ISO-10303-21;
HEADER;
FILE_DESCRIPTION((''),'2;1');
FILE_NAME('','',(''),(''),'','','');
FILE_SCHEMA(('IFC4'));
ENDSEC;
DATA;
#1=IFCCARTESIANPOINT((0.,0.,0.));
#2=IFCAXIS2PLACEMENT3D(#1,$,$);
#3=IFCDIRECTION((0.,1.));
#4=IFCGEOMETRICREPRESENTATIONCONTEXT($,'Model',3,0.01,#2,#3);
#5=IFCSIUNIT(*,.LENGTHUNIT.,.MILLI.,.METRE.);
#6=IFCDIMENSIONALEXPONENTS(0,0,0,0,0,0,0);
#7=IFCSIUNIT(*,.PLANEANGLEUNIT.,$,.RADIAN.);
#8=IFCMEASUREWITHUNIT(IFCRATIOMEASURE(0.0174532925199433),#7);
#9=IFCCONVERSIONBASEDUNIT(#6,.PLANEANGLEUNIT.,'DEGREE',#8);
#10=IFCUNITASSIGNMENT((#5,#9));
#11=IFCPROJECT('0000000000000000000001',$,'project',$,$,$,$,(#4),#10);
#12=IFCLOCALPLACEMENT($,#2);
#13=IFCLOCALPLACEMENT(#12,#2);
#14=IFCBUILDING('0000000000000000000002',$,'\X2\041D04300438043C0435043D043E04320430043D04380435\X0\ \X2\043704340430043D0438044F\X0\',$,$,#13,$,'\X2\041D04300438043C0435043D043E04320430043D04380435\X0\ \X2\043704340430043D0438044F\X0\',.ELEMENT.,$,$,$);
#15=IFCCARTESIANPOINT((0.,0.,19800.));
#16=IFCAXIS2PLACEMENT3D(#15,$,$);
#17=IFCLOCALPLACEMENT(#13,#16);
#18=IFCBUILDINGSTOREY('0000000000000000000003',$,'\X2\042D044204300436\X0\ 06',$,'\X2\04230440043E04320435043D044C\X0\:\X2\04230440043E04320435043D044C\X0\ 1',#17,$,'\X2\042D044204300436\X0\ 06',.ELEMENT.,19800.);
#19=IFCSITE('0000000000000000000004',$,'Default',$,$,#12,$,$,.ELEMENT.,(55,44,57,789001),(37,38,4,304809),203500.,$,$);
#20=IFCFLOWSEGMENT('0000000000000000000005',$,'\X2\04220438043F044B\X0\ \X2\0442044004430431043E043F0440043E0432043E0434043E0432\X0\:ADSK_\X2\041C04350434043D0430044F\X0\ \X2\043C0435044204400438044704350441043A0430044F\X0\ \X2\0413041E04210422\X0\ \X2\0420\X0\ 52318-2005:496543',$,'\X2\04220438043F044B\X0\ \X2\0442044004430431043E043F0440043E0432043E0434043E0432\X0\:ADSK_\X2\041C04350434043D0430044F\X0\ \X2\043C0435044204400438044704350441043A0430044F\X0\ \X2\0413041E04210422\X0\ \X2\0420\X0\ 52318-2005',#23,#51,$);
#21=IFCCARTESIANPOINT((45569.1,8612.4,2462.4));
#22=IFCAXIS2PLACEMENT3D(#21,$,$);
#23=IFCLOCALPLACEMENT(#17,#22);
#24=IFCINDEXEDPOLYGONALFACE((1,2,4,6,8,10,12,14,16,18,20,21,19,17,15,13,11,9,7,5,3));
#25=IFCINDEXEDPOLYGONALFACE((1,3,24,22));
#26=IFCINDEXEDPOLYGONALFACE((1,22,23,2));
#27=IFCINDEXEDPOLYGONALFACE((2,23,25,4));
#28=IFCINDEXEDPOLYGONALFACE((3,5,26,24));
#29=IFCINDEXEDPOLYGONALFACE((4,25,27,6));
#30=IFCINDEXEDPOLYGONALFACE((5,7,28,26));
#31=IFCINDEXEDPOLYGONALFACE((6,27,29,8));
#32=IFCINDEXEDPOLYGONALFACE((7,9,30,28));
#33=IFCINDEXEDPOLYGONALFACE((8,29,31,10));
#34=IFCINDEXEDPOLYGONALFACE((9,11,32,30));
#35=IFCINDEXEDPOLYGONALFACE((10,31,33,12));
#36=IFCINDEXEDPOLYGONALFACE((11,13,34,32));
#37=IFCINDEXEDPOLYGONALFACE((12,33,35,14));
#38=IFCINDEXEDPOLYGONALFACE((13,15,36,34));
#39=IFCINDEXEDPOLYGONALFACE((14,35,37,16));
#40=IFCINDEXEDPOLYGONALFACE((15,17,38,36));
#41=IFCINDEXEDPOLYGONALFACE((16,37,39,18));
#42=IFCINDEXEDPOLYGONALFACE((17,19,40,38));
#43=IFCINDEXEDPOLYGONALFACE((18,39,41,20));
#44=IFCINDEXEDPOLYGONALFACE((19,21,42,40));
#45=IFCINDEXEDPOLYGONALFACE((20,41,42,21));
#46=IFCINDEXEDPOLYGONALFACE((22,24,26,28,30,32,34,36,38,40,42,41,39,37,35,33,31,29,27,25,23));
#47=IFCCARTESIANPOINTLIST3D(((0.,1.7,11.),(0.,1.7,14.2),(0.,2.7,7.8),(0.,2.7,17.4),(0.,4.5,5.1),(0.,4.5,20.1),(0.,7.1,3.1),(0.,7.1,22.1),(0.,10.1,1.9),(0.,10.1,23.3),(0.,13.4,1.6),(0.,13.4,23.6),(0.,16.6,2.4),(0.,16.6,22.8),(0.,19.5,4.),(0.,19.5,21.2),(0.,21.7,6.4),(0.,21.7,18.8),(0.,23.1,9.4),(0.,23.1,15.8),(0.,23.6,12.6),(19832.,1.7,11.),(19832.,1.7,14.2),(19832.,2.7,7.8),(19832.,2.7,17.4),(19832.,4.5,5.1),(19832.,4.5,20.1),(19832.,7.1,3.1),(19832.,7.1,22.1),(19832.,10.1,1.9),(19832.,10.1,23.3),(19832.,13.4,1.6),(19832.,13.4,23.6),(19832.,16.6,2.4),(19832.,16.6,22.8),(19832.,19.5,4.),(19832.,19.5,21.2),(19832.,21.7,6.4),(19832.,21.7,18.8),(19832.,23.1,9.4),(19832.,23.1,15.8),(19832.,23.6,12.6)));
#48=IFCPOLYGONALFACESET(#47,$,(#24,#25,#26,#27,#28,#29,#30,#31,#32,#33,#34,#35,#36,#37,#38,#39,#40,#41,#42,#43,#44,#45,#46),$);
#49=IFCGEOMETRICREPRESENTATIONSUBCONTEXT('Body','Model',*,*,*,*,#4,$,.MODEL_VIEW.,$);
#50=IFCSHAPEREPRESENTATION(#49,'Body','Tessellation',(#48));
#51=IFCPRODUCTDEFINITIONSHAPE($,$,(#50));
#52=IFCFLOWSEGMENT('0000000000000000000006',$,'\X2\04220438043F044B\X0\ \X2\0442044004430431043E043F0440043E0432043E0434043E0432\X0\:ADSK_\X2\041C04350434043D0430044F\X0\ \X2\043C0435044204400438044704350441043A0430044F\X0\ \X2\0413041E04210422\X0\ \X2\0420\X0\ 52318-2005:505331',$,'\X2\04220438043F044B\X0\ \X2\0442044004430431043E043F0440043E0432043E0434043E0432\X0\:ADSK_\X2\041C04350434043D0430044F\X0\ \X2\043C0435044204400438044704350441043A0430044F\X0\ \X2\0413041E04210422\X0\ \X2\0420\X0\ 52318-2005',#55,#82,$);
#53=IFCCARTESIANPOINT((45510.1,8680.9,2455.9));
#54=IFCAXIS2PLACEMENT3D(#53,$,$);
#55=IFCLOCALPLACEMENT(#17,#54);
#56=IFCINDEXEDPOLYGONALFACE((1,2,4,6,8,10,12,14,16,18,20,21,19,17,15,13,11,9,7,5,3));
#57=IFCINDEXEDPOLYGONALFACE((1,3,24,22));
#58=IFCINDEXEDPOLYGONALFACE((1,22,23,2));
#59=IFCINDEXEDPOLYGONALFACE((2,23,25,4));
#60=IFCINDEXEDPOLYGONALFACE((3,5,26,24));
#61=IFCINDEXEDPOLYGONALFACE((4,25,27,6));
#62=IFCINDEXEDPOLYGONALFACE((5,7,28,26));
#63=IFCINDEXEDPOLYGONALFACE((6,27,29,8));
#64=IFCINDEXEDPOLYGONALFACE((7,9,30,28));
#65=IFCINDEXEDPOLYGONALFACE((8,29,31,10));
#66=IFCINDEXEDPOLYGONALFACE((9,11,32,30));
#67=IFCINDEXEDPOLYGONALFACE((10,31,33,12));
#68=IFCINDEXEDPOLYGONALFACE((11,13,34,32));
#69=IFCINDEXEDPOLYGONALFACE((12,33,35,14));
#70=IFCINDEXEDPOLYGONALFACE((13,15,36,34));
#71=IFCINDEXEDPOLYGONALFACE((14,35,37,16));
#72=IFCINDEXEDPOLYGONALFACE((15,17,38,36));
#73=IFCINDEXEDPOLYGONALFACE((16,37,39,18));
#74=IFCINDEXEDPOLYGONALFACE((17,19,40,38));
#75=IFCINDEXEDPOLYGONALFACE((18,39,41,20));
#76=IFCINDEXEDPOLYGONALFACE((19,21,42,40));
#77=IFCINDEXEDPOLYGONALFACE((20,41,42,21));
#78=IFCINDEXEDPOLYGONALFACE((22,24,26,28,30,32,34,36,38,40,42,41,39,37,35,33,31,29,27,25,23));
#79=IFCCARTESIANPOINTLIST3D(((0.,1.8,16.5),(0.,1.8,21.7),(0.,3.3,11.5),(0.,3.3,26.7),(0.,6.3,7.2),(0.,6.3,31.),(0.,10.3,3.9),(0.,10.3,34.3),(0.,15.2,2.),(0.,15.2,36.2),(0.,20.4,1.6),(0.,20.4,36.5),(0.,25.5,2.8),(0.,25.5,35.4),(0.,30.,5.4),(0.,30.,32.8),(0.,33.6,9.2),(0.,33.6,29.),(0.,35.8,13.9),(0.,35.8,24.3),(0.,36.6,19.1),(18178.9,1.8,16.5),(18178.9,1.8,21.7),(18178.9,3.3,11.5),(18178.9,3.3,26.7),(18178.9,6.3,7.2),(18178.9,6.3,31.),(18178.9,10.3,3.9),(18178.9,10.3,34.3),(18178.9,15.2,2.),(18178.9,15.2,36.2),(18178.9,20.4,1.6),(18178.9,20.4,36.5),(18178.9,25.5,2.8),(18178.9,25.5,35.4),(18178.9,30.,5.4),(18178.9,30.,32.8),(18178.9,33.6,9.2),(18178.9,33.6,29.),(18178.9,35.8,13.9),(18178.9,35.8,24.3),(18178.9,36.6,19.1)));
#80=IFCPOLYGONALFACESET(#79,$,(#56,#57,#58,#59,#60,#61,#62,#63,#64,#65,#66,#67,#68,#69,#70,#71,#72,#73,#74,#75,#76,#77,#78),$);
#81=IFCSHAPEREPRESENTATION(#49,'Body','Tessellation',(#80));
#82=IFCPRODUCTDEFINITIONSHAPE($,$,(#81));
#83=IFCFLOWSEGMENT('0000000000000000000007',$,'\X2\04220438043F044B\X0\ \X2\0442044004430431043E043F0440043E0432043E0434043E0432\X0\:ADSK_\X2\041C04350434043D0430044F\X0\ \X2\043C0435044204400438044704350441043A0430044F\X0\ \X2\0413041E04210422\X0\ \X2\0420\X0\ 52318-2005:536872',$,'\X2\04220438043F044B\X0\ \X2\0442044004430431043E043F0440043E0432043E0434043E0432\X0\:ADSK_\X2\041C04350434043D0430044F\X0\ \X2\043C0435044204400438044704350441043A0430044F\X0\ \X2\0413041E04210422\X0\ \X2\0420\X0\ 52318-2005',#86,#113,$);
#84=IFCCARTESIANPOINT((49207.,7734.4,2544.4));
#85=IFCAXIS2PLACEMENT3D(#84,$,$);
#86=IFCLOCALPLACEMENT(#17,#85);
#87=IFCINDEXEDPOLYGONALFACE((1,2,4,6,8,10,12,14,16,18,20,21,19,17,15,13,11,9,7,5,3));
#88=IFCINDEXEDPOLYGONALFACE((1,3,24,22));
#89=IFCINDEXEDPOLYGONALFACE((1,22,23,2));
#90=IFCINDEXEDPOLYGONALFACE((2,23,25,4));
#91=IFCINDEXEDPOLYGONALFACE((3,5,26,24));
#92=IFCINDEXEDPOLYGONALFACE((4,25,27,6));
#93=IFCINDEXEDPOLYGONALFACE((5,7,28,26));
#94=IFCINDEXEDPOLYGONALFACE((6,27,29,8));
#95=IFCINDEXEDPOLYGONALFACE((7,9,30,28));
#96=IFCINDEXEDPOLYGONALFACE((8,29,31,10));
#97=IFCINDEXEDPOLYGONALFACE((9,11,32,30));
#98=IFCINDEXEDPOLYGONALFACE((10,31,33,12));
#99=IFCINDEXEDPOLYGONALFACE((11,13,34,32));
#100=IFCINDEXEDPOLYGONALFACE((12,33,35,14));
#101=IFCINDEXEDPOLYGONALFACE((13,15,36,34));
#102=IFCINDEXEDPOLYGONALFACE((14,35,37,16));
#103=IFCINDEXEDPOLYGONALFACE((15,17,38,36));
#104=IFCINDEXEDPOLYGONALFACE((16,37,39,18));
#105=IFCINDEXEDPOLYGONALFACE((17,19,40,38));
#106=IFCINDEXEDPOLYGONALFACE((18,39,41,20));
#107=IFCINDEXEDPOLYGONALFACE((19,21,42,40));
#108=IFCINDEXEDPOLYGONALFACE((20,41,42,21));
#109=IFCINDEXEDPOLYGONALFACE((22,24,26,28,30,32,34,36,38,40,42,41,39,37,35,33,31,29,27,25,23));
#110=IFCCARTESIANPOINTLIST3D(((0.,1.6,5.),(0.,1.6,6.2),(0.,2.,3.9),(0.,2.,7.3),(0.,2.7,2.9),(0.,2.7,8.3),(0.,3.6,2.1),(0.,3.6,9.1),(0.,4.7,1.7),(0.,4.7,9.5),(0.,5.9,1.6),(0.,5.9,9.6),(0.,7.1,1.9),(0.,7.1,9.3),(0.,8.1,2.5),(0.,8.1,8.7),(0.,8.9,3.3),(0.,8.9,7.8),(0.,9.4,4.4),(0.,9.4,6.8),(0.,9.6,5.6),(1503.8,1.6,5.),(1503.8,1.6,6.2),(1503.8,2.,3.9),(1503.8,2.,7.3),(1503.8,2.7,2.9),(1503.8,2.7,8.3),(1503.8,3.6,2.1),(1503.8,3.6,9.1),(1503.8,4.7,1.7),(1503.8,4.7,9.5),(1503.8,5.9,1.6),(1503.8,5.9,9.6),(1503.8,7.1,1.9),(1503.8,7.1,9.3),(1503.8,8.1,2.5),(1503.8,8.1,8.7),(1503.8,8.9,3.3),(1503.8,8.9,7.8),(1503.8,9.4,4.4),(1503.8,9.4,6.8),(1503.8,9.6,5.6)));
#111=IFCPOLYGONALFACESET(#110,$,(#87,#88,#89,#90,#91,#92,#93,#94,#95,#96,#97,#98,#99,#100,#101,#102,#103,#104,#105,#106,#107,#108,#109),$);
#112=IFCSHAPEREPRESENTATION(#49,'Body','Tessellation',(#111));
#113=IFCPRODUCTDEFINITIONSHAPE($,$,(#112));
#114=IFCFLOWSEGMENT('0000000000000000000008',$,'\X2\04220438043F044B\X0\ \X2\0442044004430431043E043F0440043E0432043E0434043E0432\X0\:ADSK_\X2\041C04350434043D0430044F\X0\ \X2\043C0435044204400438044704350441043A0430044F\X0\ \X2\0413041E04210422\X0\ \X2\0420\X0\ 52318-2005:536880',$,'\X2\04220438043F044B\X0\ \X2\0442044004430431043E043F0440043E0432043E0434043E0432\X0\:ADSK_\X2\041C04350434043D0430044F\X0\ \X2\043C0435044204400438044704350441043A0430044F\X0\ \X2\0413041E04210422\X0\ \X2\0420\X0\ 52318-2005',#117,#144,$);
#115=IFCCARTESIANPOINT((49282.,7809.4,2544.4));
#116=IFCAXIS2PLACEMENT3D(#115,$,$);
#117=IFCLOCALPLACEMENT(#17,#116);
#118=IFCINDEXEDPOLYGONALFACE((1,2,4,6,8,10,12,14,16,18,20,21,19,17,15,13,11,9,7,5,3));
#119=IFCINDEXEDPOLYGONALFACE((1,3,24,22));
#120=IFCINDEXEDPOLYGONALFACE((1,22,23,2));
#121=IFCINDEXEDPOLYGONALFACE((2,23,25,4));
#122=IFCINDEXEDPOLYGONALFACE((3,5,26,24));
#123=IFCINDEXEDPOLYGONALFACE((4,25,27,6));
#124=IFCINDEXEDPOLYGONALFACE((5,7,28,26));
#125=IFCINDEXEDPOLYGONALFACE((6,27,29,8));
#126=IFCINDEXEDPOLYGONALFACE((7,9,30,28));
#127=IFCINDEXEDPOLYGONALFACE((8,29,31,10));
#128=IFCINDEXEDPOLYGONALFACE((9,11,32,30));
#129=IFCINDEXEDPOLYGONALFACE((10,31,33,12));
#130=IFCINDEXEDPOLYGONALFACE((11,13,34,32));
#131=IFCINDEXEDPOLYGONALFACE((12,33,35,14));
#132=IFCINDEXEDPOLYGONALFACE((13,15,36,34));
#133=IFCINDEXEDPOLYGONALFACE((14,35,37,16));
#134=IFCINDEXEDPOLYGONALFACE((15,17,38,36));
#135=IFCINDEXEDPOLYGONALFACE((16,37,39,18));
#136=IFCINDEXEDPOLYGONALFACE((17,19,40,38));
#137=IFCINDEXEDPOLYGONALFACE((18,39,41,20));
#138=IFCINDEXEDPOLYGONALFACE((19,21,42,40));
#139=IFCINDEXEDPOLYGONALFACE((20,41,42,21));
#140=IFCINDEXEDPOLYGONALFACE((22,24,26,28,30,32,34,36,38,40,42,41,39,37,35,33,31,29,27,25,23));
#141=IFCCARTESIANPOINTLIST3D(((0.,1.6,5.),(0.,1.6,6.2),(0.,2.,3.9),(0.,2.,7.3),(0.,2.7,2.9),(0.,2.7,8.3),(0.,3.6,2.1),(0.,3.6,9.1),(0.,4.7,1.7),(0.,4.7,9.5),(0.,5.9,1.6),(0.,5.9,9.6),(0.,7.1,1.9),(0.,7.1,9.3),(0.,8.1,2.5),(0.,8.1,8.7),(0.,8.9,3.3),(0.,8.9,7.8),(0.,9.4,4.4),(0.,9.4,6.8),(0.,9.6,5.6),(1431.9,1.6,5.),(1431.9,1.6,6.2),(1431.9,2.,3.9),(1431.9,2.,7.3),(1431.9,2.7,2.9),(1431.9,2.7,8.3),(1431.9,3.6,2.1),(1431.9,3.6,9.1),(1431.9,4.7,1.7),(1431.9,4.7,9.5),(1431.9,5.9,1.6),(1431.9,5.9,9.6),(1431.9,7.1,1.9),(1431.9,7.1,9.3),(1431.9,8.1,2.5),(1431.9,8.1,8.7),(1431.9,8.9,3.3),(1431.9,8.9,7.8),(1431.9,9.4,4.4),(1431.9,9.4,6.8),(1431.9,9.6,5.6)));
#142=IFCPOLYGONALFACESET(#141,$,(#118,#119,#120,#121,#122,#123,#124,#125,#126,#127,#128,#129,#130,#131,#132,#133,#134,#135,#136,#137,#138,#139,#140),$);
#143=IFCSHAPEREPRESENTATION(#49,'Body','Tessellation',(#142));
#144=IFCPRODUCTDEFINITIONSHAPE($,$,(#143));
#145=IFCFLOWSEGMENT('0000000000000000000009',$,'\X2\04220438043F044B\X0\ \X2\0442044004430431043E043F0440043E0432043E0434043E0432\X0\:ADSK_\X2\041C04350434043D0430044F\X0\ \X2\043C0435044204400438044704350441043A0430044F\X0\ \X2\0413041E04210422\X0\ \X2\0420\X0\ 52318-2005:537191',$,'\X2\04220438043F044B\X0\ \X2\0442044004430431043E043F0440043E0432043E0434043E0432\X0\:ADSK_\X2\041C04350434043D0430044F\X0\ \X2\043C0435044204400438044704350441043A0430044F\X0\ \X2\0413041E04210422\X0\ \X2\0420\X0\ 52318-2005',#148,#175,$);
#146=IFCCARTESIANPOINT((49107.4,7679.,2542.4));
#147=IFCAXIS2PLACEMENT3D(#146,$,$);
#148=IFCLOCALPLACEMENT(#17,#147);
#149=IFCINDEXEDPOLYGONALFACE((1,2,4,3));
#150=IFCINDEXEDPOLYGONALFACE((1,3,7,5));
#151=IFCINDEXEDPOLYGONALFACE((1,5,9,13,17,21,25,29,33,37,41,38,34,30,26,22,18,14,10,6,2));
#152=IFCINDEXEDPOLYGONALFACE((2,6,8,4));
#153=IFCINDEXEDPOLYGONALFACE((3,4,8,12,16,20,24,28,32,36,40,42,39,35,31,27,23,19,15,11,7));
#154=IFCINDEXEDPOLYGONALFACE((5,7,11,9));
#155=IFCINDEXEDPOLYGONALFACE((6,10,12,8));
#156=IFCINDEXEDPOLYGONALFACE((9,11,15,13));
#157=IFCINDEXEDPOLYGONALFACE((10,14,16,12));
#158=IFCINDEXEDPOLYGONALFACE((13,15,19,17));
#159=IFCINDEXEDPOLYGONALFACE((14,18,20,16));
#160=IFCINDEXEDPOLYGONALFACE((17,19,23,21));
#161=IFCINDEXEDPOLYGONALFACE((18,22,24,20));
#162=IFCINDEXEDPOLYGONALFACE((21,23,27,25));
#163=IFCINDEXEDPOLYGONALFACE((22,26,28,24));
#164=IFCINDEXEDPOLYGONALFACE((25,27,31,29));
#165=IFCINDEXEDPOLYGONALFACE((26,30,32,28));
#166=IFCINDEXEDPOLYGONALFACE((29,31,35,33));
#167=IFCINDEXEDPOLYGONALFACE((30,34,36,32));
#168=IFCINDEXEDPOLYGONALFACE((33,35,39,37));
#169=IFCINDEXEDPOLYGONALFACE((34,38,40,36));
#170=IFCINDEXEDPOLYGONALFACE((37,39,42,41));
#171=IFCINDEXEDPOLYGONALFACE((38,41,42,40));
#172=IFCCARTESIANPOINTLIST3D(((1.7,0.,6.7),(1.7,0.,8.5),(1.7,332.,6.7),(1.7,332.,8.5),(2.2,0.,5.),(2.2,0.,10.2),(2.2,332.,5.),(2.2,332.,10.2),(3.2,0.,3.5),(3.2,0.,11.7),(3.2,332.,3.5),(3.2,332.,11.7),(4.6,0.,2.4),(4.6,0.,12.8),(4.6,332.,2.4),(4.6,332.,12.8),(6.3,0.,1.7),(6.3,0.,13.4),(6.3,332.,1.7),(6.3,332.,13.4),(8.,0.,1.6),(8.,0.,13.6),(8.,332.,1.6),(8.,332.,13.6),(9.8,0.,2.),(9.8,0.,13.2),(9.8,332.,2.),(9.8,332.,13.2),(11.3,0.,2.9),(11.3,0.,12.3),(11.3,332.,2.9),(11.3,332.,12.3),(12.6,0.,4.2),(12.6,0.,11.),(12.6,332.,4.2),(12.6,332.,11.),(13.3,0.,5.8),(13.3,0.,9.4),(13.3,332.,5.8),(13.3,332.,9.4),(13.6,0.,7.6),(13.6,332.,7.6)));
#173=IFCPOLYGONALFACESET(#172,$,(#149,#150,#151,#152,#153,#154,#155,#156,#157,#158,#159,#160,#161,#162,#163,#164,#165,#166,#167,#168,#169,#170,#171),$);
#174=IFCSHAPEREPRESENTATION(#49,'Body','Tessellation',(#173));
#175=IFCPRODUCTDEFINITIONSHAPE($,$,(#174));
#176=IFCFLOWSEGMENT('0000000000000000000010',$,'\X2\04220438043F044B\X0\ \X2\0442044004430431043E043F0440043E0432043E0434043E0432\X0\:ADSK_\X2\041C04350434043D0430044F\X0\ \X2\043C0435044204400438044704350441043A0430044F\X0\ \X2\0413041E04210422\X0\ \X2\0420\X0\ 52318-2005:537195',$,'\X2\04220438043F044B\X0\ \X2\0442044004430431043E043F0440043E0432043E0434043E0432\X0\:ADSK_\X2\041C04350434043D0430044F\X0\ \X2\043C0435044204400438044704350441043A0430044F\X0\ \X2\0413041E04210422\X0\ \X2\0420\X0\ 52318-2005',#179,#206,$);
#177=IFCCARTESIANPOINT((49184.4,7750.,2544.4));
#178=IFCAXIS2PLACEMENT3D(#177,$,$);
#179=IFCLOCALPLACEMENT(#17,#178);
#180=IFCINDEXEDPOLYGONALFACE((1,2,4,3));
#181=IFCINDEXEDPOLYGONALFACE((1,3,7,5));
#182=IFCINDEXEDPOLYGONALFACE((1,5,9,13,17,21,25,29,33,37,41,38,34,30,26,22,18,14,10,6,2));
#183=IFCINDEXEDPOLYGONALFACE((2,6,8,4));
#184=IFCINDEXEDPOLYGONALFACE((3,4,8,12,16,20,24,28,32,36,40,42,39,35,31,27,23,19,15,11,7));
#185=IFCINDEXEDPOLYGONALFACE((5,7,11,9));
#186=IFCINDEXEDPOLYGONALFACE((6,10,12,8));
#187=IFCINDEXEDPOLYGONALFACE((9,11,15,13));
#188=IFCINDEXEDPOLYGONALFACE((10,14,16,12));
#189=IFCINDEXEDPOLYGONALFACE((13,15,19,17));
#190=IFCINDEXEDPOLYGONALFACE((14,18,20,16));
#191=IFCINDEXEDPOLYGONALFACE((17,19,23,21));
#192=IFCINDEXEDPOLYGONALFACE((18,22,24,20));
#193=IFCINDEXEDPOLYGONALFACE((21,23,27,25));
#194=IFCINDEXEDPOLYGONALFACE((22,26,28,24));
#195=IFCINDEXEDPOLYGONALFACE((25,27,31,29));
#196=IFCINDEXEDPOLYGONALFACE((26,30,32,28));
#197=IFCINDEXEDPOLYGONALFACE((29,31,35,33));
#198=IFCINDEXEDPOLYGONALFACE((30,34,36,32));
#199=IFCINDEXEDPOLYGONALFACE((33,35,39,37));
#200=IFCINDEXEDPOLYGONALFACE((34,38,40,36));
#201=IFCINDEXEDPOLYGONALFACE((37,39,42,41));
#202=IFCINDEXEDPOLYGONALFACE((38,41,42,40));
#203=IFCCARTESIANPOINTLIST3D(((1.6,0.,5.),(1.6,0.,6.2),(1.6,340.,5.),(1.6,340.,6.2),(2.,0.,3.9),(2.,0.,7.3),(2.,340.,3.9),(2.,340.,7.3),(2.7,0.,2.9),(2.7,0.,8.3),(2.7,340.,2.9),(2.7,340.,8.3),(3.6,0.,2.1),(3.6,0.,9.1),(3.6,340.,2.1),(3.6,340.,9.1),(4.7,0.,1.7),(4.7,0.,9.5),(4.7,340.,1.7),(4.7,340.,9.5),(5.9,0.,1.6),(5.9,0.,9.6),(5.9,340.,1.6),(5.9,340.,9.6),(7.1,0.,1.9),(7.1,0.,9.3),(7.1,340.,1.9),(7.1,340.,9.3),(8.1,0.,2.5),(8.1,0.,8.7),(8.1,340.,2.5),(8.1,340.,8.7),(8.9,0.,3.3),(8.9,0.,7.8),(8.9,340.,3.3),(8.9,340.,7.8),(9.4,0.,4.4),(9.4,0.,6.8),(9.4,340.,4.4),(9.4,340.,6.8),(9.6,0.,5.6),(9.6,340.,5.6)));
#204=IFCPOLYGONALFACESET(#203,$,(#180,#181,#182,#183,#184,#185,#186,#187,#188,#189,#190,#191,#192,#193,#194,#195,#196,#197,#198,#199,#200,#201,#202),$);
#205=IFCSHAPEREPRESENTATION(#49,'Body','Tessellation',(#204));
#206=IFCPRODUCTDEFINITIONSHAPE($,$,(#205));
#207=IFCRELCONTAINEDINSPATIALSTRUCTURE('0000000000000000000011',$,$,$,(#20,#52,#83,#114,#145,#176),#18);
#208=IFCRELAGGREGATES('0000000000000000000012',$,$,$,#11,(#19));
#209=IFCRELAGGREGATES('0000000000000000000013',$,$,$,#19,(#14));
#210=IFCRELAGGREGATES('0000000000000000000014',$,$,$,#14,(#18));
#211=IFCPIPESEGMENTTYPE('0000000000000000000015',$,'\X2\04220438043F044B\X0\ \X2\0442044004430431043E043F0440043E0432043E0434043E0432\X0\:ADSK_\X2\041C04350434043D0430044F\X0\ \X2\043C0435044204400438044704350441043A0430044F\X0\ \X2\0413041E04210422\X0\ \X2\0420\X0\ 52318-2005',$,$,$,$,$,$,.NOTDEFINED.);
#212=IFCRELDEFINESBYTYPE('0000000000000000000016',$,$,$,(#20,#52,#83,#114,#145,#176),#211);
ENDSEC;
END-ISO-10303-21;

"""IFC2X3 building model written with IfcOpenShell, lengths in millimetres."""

from ifc_helpers import new_model, entity, si_unit, converted_unit, direction, frame, frame_2d, origin, origin_2d_with_axis, place, context, subcontext, project, spatial, circle, extrude, type_object, element, save


model = new_model("IFC2X3")

# Units and contexts
model_context = context("Model", 3, precision=0.01, world=origin(), true_north=direction((0.0, 1.0)))
body_context = subcontext(model_context, "Body", "Model", "MODEL_VIEW")
ifc_project = project(units=[si_unit("LENGTHUNIT", "METRE", prefix="MILLI"), converted_unit("PLANEANGLEUNIT", "DEGREE", entity("IfcRatioMeasure", 0.0174532925199433), si_unit("PLANEANGLEUNIT", "RADIAN"), dimensions=[0, 0, 0, 0, 0, 0, 0])], contexts=[model_context])

# Site, building, storey
site_placement = place(None, frame((0.0, 0.0, 0.0)))
site = spatial("IfcSite", under=ifc_project, at=site_placement, Name="Default", CompositionType="ELEMENT", RefLatitude=(55, 44, 57, 789001), RefLongitude=(37, 38, 4, 304809), RefElevation=203500.0)
building_placement = place(site_placement, origin())
building = spatial("IfcBuilding", under=site, at=building_placement, Name="Наименование здания", LongName="Наименование здания", CompositionType="ELEMENT")
storey_placement = place(building_placement, frame((0.0, 0.0, 19800.0)))
storey = spatial("IfcBuildingStorey", under=building, at=storey_placement, Name="Этаж 06", ObjectType="Уровень:Уровень 1", LongName="Этаж 06", CompositionType="ELEMENT", Elevation=19800.0)

# Flow segments
pipe_segment_type = type_object("IfcPipeSegmentType", Name="Типы трубопроводов:ADSK_Медная метрическая ГОСТ Р 52318-2005", PredefinedType="NOTDEFINED")
flow_segment_1_placement = place(storey_placement, frame((45569.1, 8612.4, 2462.4)))
element("IfcFlowSegment", 1, at=flow_segment_1_placement, inside=storey, type_object=pipe_segment_type, Name="Типы трубопроводов:ADSK_Медная метрическая ГОСТ Р 52318-2005:496543", ObjectType="Типы трубопроводов:ADSK_Медная метрическая ГОСТ Р 52318-2005", context=body_context, shape_type="SweptSolid", body=[
    extrude(circle(Radius=11.0, at=frame_2d((0.0, 0.0), x_axis=(1.0, 0.0))), frame((0.0, 12.6, 12.6), z_axis=(1.0, 0.0, 0.0), x_axis=(0.0, 1.0, 0.0)), (0.0, 0.0, 1.0), 19832.0),
])
flow_segment_2_placement = place(storey_placement, frame((45510.1, 8680.9, 2455.9)))
element("IfcFlowSegment", 2, at=flow_segment_2_placement, inside=storey, type_object=pipe_segment_type, Name="Типы трубопроводов:ADSK_Медная метрическая ГОСТ Р 52318-2005:505331", ObjectType="Типы трубопроводов:ADSK_Медная метрическая ГОСТ Р 52318-2005", context=body_context, shape_type="SweptSolid", body=[
    extrude(circle(Radius=17.5, at=origin_2d_with_axis()), frame((0.0, 19.1, 19.1), z_axis=(1.0, 0.0, 0.0), x_axis=(0.0, 1.0, 0.0)), (0.0, 0.0, 1.0), 18178.9),
])
flow_segment_3_placement = place(storey_placement, frame((49207.0, 7734.4, 2544.4)))
element("IfcFlowSegment", 3, at=flow_segment_3_placement, inside=storey, type_object=pipe_segment_type, Name="Типы трубопроводов:ADSK_Медная метрическая ГОСТ Р 52318-2005:536872", ObjectType="Типы трубопроводов:ADSK_Медная метрическая ГОСТ Р 52318-2005", context=body_context, shape_type="SweptSolid", body=[
    extrude(circle(Radius=4.0, at=frame_2d((0.0, 0.0), x_axis=(1.0, 0.0))), frame((0.0, 5.6, 5.6), z_axis=(1.0, 0.0, 0.0), x_axis=(0.0, 1.0, 0.0)), (0.0, 0.0, 1.0), 1503.8),
])
flow_segment_4_placement = place(storey_placement, frame((49282.0, 7809.4, 2544.4)))
element("IfcFlowSegment", 4, at=flow_segment_4_placement, inside=storey, type_object=pipe_segment_type, Name="Типы трубопроводов:ADSK_Медная метрическая ГОСТ Р 52318-2005:536880", ObjectType="Типы трубопроводов:ADSK_Медная метрическая ГОСТ Р 52318-2005", context=body_context, shape_type="SweptSolid", body=[
    extrude(circle(Radius=4.0, at=frame_2d((0.0, 0.0), x_axis=(1.0, 0.0))), frame((0.0, 5.6, 5.6), z_axis=(1.0, 0.0, 0.0), x_axis=(0.0, 1.0, 0.0)), (0.0, 0.0, 1.0), 1431.9),
])
flow_segment_5_placement = place(storey_placement, frame((49107.4, 7679.0, 2542.4)))
element("IfcFlowSegment", 5, at=flow_segment_5_placement, inside=storey, type_object=pipe_segment_type, Name="Типы трубопроводов:ADSK_Медная метрическая ГОСТ Р 52318-2005:537191", ObjectType="Типы трубопроводов:ADSK_Медная метрическая ГОСТ Р 52318-2005", context=body_context, shape_type="SweptSolid", body=[
    extrude(circle(Radius=6.0, at=origin_2d_with_axis()), frame((7.6, 0.0, 7.6), z_axis=(0.0, 1.0, 0.0), x_axis=(1.0, 0.0, 0.0)), (0.0, 0.0, 1.0), 332.0),
])
for number, where, name in (
    (6, (49184.4, 7750.0, 2544.4), "Типы трубопроводов:ADSK_Медная метрическая ГОСТ Р 52318-2005:537195"),
):
    element("IfcFlowSegment", number, at=place(storey_placement, frame(where)), inside=storey, type_object=pipe_segment_type, Name=name, ObjectType="Типы трубопроводов:ADSK_Медная метрическая ГОСТ Р 52318-2005", context=body_context, shape_type="SweptSolid", body=[
        extrude(circle(Radius=4.0, at=origin_2d_with_axis()), frame((5.6, 0.0, 5.6), z_axis=(0.0, 1.0, 0.0), x_axis=(1.0, 0.0, 0.0)), (0.0, 0.0, 1.0), 340.0),
    ])

save(model, "model.ifc")
